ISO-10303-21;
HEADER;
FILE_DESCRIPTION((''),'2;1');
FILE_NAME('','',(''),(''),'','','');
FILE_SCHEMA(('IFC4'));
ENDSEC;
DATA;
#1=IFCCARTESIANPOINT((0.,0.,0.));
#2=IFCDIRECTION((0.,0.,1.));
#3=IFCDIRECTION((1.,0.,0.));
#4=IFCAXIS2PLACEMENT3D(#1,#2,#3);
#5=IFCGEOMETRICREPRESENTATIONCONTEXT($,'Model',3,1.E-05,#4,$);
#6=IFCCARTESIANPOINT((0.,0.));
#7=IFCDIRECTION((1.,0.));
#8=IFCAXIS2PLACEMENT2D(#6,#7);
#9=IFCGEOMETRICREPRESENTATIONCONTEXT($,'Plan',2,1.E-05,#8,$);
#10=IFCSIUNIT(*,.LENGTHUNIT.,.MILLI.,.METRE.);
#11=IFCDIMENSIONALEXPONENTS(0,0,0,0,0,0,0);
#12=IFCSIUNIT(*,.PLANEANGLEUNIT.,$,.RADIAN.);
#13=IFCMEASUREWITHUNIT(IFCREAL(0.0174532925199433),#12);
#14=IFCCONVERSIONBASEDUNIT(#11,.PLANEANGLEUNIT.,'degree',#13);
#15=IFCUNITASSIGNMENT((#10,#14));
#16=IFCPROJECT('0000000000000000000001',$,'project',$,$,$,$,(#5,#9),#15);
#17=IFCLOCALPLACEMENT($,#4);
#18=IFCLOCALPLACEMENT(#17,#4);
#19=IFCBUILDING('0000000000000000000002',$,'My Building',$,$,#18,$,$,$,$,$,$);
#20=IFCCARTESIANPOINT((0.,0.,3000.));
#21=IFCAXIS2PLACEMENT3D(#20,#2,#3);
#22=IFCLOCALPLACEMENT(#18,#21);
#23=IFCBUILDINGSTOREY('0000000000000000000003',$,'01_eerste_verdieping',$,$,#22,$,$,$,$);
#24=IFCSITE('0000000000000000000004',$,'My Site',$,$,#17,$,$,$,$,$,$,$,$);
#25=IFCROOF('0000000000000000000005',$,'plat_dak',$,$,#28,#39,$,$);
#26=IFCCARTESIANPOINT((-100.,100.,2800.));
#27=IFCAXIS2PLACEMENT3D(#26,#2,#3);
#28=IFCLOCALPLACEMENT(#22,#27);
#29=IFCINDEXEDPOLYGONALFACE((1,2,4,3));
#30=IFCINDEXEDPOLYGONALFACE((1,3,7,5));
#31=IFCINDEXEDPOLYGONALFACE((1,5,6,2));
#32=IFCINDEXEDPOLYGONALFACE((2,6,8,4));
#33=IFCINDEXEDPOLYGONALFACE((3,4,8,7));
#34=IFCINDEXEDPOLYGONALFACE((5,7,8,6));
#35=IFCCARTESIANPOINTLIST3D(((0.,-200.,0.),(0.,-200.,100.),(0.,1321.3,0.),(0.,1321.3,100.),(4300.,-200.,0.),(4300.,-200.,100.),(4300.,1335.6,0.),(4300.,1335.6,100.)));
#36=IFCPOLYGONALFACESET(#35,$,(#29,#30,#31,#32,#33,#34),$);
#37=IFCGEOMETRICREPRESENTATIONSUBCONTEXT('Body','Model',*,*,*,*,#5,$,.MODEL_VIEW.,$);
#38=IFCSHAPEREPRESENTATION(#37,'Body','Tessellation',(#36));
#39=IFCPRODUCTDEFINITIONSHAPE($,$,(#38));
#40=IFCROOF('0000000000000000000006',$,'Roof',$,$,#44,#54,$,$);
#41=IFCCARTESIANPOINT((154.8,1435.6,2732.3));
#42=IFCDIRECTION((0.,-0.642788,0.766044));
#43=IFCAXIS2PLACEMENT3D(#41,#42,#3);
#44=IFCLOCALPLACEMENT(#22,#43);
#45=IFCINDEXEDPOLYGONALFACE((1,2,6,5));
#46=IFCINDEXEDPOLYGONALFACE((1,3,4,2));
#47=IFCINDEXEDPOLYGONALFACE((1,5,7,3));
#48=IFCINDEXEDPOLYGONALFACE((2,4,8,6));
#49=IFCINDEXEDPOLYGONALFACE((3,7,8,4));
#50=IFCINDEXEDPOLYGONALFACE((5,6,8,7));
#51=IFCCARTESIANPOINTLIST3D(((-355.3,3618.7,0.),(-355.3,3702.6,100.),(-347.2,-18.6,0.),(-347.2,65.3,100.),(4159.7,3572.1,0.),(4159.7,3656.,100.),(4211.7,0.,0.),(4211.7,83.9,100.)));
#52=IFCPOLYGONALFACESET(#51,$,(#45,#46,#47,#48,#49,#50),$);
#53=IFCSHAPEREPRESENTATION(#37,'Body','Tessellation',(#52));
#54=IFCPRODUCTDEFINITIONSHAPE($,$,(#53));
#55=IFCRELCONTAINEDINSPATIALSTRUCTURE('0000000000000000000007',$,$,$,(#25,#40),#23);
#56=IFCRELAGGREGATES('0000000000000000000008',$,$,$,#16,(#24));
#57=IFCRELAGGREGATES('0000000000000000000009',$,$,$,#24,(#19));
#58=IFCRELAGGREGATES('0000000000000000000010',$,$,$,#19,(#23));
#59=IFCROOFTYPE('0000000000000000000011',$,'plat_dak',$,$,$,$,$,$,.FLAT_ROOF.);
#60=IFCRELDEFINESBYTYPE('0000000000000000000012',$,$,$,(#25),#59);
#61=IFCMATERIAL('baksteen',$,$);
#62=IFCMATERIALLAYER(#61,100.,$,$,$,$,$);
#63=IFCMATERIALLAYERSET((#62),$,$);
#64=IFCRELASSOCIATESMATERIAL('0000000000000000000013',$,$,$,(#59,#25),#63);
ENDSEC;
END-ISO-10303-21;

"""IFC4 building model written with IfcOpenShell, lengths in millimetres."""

from ifc_helpers import new_model, entity, si_unit, converted_unit, frame, origin_with_axes, origin_2d_with_axis, place, context, subcontext, project, spatial, line, indexed_curve, outline, extrude, material, layer, layer_set, layer_usage, type_object, element, save


model = new_model("IFC4")

# Units and contexts
model_context = context("Model", 3, precision=1e-05, world=origin_with_axes())
plan_context = context("Plan", 2, precision=1e-05, world=origin_2d_with_axis())
body_context = subcontext(model_context, "Body", "Model", "MODEL_VIEW")
ifc_project = project(units=[si_unit("LENGTHUNIT", "METRE", prefix="MILLI"), converted_unit("PLANEANGLEUNIT", "degree", entity("IfcReal", 0.0174532925199433), si_unit("PLANEANGLEUNIT", "RADIAN"), dimensions=[0, 0, 0, 0, 0, 0, 0])], contexts=[model_context, plan_context])

# Site, building, storey
site_placement = place(None, origin_with_axes())
site = spatial("IfcSite", under=ifc_project, at=site_placement, Name="My Site")
building_placement = place(site_placement, origin_with_axes())
building = spatial("IfcBuilding", under=site, at=building_placement, Name="My Building")
storey_placement = place(building_placement, frame((0.0, 0.0, 3000.0), z_axis=(0.0, 0.0, 1.0), x_axis=(1.0, 0.0, 0.0)))
storey = spatial("IfcBuildingStorey", under=building, at=storey_placement, Name="01_eerste_verdieping")

# Shared definitions
ifc_material = material(Name="baksteen")

# Roofs
ifc_layer = layer(ifc_material, 100.0)
ifc_layer_set = layer_set([ifc_layer])
ifc_layer_usage = layer_usage(ifc_layer_set, "AXIS3", "POSITIVE", 0.0)
roof_type = type_object("IfcRoofType", Name="plat_dak", PredefinedType="FLAT_ROOF", material=ifc_layer_set)
roof_1_placement = place(storey_placement, frame((-100.0, 100.0, 2800.0), z_axis=(0.0, 0.0, 1.0), x_axis=(1.0, 0.0, 0.0)))
element("IfcRoof", 1, at=roof_1_placement, inside=storey, type_object=roof_type, material=ifc_layer_usage, Name="plat_dak", context=body_context, shape_type="SweptSolid", body=[
    extrude(outline(indexed_curve([(4300.0, -200.0), (0.0, -200.0), (0.0, 1321.3), (4300.0, 1335.6)], segments=[line(4, 1), line(1, 2), line(2, 3), line(3, 4)], self_intersect=False)), None, (0.0, 0.0, 1.0), 100.0),
])
roof_2_placement = place(storey_placement, frame((154.8, 1435.6, 2732.3), z_axis=(0.0, -0.642788, 0.766044), x_axis=(1.0, 0.0, 0.0)))
element("IfcRoof", 2, at=roof_2_placement, inside=storey, Name="Roof", context=body_context, shape_type="SweptSolid", body=[
    extrude(outline(indexed_curve([(-355.3, 3618.7), (-347.2, -18.6), (4211.7, 0.0), (4159.7, 3572.1)], segments=[line(3, 2), line(2, 1), line(1, 4), line(4, 3)], self_intersect=False)), None, (0.0, 0.642788, 0.766044), 130.5),
])

save(model, "model.ifc")
